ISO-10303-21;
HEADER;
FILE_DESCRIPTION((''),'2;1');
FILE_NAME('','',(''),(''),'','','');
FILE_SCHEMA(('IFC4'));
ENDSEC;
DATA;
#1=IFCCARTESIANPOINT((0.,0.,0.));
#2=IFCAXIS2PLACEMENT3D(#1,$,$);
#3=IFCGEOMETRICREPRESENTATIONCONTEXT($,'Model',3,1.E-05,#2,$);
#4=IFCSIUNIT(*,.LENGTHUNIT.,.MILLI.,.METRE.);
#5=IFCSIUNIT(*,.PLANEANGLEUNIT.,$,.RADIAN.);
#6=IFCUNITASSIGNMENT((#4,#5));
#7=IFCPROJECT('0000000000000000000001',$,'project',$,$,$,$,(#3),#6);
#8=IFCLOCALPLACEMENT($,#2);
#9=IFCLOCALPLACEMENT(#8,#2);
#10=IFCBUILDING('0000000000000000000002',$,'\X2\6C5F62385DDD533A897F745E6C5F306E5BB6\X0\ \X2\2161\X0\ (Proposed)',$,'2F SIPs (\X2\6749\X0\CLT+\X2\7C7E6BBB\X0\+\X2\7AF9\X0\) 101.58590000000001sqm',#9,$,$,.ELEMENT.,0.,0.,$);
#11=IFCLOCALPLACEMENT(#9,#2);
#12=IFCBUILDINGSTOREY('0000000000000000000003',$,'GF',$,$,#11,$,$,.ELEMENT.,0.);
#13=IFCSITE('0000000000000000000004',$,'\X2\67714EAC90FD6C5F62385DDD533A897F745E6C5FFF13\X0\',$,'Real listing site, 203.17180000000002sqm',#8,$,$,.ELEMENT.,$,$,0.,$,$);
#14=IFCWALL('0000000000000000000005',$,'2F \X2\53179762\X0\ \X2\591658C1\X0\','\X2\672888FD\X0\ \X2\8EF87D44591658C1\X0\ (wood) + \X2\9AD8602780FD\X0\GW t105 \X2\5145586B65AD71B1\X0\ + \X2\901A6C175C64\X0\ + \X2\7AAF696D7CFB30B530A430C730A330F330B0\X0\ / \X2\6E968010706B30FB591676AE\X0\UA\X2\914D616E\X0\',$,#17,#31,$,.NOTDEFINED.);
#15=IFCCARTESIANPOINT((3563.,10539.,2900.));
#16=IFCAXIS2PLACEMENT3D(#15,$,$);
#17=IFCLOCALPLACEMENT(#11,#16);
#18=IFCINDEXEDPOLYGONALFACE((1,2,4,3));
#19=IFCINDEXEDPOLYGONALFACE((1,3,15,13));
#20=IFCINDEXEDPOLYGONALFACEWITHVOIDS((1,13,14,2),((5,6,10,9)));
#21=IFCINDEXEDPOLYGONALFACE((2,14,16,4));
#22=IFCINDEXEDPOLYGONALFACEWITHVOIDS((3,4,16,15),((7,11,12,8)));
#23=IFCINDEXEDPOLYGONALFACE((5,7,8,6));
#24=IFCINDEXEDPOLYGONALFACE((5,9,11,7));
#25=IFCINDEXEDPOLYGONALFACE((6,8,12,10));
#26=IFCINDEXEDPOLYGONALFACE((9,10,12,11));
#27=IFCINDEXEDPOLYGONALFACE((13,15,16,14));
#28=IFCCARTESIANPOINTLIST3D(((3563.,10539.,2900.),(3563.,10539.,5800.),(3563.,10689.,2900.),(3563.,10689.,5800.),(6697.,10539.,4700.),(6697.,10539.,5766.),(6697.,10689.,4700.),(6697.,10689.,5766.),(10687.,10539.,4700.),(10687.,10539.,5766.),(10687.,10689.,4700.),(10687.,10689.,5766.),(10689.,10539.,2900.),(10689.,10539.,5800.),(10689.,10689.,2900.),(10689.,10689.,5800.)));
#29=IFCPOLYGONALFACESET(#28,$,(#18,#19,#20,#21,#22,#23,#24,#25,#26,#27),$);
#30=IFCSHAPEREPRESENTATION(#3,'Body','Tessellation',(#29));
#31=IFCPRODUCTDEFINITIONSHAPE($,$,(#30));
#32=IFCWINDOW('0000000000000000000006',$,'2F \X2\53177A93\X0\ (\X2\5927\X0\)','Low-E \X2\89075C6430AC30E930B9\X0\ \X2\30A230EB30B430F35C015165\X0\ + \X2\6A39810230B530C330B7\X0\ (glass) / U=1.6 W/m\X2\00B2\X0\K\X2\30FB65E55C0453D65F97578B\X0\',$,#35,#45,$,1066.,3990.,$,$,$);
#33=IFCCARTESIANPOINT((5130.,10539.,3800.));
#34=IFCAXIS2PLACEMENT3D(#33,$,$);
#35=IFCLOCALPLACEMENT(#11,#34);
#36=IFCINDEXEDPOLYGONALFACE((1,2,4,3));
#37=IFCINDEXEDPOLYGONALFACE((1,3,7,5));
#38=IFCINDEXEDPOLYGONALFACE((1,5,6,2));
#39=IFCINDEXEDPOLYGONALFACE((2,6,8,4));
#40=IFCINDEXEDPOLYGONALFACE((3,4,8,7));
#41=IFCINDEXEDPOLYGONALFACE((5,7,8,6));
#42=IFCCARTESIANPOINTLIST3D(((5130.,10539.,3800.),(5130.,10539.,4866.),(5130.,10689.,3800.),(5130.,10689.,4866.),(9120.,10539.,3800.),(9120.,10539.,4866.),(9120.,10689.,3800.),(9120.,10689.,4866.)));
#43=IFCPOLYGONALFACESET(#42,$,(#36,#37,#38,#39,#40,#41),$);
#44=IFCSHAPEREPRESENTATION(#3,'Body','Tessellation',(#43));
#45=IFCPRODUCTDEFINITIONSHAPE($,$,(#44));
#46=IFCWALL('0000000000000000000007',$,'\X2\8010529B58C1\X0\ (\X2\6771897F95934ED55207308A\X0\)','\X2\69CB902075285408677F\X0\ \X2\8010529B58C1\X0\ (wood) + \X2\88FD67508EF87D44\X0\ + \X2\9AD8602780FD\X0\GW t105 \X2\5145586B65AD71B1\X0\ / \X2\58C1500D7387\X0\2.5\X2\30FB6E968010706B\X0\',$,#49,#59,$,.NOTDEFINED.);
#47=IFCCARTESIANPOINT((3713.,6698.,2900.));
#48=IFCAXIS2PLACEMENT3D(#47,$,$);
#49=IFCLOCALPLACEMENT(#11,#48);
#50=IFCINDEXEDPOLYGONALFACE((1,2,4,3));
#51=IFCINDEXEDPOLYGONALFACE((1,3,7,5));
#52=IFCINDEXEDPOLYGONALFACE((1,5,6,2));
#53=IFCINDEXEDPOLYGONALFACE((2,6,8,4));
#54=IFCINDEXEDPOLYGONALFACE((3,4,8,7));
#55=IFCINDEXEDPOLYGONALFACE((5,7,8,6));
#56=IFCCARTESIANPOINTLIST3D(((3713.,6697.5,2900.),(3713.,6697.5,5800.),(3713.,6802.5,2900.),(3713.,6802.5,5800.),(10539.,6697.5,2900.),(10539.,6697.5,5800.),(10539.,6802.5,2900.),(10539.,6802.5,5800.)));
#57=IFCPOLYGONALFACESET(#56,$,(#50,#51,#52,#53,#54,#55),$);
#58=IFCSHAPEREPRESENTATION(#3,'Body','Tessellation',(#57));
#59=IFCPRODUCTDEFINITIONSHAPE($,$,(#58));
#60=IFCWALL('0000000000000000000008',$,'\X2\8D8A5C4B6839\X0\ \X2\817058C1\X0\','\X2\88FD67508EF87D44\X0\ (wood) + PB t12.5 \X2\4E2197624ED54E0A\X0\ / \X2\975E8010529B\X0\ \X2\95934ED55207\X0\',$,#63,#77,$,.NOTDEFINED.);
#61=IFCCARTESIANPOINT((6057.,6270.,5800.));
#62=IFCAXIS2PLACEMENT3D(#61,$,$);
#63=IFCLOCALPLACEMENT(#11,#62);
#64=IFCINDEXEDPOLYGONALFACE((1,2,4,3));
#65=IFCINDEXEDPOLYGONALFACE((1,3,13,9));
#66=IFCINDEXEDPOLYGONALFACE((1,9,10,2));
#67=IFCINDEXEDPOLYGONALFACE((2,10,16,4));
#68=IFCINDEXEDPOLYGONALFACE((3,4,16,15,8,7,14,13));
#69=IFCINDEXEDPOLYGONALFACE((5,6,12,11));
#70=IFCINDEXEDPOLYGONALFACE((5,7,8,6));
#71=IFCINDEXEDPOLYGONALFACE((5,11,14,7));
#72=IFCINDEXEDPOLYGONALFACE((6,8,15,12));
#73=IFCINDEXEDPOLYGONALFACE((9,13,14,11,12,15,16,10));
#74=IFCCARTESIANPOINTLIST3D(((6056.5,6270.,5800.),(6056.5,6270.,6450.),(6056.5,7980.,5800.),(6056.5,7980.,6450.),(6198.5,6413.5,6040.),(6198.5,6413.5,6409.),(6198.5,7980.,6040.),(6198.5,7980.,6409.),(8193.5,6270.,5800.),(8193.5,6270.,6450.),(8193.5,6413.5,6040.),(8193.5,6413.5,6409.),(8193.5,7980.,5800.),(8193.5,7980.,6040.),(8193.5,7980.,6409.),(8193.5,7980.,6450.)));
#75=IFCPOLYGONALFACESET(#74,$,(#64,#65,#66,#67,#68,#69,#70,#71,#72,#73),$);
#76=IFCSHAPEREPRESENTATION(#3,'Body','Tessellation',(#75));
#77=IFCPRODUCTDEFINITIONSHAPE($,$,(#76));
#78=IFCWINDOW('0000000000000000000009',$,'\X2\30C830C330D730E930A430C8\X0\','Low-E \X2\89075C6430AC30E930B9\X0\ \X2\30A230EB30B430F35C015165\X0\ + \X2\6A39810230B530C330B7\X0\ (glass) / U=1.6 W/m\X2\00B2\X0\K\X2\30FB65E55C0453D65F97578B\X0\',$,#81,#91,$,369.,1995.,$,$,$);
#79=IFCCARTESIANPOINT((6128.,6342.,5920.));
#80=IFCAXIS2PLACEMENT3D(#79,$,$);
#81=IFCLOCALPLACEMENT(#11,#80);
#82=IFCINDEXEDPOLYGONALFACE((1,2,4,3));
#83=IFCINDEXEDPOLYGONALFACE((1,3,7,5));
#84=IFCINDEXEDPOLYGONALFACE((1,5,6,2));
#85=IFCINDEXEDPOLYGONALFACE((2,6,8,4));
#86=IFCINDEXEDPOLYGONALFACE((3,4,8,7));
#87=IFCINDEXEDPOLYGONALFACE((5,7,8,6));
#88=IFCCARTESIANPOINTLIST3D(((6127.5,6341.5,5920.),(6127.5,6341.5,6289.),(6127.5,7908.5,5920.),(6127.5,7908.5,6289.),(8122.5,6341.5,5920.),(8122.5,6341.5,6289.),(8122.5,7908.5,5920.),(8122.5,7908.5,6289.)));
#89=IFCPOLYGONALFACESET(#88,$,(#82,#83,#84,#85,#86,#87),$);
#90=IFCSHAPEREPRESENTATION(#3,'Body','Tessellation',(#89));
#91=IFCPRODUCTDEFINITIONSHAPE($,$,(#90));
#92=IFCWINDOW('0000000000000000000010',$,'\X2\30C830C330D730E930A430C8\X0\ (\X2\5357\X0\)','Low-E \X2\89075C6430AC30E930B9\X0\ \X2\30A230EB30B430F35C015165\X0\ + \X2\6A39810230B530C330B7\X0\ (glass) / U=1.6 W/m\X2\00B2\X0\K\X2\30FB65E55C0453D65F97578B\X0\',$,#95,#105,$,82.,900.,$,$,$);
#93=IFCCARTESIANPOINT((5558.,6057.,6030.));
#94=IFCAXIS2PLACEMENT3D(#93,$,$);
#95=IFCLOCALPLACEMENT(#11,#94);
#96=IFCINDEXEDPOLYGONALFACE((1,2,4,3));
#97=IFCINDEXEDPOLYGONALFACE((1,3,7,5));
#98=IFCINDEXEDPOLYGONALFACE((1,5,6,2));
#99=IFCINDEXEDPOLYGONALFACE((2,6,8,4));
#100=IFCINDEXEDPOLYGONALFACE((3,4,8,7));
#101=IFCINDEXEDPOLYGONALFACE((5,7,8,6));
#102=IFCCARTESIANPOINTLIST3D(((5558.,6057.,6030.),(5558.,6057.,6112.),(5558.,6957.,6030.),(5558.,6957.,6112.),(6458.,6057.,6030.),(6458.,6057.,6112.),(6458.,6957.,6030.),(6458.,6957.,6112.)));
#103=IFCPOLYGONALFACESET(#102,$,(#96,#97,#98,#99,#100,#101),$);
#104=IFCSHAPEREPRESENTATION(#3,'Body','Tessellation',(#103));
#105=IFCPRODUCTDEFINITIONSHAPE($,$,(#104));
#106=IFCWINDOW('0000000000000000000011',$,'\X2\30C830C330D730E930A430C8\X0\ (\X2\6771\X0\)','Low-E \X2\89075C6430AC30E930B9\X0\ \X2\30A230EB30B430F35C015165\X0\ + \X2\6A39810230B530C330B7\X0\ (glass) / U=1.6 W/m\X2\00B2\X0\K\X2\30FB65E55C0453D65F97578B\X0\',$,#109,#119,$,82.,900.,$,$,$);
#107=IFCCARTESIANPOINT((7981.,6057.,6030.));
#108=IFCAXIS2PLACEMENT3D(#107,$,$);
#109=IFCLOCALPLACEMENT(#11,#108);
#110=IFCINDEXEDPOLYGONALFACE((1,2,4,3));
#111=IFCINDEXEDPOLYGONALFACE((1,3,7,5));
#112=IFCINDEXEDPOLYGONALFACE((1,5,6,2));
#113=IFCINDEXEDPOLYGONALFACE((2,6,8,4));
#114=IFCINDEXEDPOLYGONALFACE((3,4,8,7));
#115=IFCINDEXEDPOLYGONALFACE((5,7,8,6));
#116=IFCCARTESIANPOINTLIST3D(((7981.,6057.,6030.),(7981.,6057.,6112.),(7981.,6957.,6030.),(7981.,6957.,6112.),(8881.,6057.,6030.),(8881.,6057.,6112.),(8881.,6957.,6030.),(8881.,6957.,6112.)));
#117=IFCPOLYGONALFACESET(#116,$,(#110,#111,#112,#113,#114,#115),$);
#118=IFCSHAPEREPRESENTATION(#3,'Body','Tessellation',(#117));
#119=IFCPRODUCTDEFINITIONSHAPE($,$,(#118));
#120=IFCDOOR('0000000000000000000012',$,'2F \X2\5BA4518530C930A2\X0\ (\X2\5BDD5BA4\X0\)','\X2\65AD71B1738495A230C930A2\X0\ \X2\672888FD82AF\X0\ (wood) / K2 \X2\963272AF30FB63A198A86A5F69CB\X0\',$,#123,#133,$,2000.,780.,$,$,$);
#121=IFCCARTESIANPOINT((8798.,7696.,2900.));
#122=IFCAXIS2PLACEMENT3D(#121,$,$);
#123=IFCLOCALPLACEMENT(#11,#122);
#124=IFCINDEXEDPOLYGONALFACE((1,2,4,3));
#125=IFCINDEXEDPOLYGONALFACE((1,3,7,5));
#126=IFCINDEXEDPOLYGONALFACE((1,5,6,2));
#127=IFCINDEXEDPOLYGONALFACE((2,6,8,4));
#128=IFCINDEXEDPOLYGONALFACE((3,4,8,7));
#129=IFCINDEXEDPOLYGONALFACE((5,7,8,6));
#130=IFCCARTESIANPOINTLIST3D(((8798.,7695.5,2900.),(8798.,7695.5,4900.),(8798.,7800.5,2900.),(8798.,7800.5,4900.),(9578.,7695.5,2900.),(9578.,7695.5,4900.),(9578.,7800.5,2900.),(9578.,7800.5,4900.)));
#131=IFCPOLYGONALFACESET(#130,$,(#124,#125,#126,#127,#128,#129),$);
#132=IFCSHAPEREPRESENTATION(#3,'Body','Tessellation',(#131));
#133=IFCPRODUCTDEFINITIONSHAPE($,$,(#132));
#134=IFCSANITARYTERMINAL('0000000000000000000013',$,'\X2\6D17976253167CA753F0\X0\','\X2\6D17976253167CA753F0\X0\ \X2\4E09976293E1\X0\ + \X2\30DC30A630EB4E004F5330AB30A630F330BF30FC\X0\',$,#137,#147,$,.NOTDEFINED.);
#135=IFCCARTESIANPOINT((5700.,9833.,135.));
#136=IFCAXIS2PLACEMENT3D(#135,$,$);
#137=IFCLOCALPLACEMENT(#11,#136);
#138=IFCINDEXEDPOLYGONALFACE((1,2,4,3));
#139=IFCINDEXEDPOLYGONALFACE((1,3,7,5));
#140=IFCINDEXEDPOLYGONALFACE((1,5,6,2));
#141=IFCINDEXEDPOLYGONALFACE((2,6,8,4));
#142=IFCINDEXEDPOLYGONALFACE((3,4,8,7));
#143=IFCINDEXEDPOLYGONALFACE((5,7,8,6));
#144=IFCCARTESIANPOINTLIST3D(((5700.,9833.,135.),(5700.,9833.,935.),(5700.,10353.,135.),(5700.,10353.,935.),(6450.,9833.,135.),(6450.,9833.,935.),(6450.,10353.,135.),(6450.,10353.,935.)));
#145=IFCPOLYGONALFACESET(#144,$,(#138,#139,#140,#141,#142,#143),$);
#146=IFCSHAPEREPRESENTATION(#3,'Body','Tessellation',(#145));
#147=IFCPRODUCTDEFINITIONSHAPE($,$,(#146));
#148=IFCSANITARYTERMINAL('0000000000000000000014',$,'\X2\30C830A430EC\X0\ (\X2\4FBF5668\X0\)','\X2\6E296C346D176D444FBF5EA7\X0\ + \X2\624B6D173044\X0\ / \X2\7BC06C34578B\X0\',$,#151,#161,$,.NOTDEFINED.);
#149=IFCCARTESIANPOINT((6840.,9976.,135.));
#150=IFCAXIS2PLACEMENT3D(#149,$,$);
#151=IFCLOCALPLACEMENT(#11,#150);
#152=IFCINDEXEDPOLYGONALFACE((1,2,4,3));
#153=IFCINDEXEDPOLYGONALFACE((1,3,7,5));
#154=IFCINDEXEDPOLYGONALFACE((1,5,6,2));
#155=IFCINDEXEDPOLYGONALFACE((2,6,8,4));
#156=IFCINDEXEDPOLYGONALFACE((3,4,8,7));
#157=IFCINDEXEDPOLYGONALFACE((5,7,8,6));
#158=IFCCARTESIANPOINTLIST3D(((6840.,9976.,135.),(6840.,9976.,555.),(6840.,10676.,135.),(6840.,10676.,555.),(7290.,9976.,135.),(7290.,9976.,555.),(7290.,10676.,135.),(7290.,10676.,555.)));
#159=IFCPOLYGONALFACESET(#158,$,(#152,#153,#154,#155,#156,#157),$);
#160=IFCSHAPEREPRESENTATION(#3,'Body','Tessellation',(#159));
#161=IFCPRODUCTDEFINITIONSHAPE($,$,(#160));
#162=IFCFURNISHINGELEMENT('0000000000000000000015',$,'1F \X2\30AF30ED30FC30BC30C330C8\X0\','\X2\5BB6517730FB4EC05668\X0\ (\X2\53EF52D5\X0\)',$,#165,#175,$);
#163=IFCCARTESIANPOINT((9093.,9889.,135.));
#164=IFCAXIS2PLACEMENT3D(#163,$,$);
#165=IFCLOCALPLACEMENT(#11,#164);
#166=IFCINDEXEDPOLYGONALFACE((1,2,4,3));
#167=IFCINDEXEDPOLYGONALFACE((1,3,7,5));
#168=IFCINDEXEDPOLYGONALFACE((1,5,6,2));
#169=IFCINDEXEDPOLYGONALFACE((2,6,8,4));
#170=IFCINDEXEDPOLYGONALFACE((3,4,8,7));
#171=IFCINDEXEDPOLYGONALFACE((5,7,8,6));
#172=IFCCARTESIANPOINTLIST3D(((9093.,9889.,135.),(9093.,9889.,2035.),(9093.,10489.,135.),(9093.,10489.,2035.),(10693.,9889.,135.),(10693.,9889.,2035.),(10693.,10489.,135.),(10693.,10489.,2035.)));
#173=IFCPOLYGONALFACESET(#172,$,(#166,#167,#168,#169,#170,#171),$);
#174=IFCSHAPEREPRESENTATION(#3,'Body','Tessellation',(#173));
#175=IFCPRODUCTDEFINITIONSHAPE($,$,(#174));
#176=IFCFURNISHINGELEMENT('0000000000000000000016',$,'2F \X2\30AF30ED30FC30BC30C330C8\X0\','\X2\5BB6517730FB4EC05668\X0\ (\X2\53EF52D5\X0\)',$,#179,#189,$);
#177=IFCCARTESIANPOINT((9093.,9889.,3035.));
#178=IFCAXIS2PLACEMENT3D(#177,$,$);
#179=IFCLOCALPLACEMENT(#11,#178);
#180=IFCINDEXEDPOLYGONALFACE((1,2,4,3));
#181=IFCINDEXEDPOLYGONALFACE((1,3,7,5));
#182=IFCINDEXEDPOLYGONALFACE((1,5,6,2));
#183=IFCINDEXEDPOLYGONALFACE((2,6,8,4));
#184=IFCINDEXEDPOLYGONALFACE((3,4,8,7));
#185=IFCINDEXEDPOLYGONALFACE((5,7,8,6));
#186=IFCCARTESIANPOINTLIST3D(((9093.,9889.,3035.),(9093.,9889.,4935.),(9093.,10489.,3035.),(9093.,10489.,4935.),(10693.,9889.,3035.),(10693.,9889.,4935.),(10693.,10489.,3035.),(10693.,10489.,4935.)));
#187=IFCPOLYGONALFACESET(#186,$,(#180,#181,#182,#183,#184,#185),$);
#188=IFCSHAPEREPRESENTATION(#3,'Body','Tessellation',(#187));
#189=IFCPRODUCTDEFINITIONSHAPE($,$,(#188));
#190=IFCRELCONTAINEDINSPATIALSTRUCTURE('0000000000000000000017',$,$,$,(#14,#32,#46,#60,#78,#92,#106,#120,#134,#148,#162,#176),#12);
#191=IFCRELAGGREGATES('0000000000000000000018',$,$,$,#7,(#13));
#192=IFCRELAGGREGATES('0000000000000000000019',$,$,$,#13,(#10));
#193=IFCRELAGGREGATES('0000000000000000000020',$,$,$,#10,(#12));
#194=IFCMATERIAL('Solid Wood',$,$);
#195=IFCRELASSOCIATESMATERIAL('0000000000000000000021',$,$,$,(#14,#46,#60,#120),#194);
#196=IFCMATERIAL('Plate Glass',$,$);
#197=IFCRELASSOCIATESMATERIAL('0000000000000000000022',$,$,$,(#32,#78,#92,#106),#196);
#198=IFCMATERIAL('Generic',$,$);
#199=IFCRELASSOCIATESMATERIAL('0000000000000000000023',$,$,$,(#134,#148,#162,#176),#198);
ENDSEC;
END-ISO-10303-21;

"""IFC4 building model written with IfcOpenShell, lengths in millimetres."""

from ifc_helpers import new_model, si_unit, frame, frame_2d, origin, place, context, project, spatial, rectangle, extrude, material, element, fill, save


model = new_model("IFC4")

# Units and contexts
model_context = context("Model", 3, precision=1e-05, world=origin())
ifc_project = project(units=[si_unit("LENGTHUNIT", "METRE", prefix="MILLI"), si_unit("PLANEANGLEUNIT", "RADIAN")], contexts=[model_context])

# Site, building, storey
site_placement = place(None, origin())
site = spatial("IfcSite", under=ifc_project, at=site_placement, Name="東京都江戸川区西瑞江３", ObjectType="Real listing site, 203.17180000000002sqm", CompositionType="ELEMENT", RefElevation=0.0)
building_placement = place(site_placement, origin())
building = spatial("IfcBuilding", under=site, at=building_placement, Name="江戸川区西瑞江の家 Ⅱ (Proposed)", ObjectType="2F SIPs (杉CLT+籾殻+竹) 101.58590000000001sqm", CompositionType="ELEMENT", ElevationOfRefHeight=0.0, ElevationOfTerrain=0.0)
storey_placement = place(building_placement, origin())
storey = spatial("IfcBuildingStorey", under=building, at=storey_placement, Name="GF", CompositionType="ELEMENT", Elevation=0.0)

# Wall, opening, window
ifc_material_1 = material(Name="Solid Wood")
wall_1_placement = place(storey_placement, frame((3563.0, 10539.0, 2900.0)))
wall_1 = element("IfcWall", 1, at=wall_1_placement, inside=storey, material=ifc_material_1, Name="2F 北面 外壁", Description="木製 軸組外壁 (wood) + 高性能GW t105 充填断熱 + 通気層 + 窯業系サイディング / 準耐火・外皮UA配慮", PredefinedType="NOTDEFINED", context=model_context, shape_type="SweptSolid", body=[
    extrude(rectangle(XDim=7126.0, YDim=150.0, at=frame_2d((3563.0, 75.0))), frame((3563.0, 10539.0, 2900.0)), (0.0, 0.0, 1.0), 2900.0),
])
opening_1_placement = place(storey_placement, frame((5130.0, 10539.0, 3800.0)))
opening_1 = element("IfcOpeningElement", 2, at=opening_1_placement, cuts=wall_1, PredefinedType="NOTDEFINED", context=model_context, shape_type="SweptSolid", body=[
    extrude(rectangle(XDim=3990.0, YDim=150.0, at=frame_2d((1995.0, 75.0))), frame((5130.0, 10539.0, 3800.0)), (0.0, 0.0, 1.0), 1066.0),
])
ifc_material_2 = material(Name="Plate Glass")
window_1_placement = place(storey_placement, frame((5130.0, 10539.0, 3800.0)))
window_1 = element("IfcWindow", 3, at=window_1_placement, inside=storey, material=ifc_material_2, Name="2F 北窓 (大)", Description="Low-E 複層ガラス アルゴン封入 + 樹脂サッシ (glass) / U=1.6 W/m²K・日射取得型", OverallHeight=1066.0, OverallWidth=3990.0, context=model_context, shape_type="SweptSolid", body=[
    extrude(rectangle(XDim=3990.0, YDim=150.0, at=frame_2d((1995.0, 75.0))), frame((5130.0, 10539.0, 3800.0)), (0.0, 0.0, 1.0), 1066.0),
])
fill(opening_1, window_1)

# Wall
wall_2_placement = place(storey_placement, frame((3713.0, 6698.0, 2900.0)))
element("IfcWall", 4, at=wall_2_placement, inside=storey, material=ifc_material_1, Name="耐力壁 (東西間仕切り)", Description="構造用合板 耐力壁 (wood) + 製材軸組 + 高性能GW t105 充填断熱 / 壁倍率2.5・準耐火", PredefinedType="NOTDEFINED", context=model_context, shape_type="SweptSolid", body=[
    extrude(rectangle(XDim=6826.0, YDim=105.0, at=frame_2d((3413.0, 52.0))), frame((3713.0, 6698.0, 2900.0)), (0.0, 0.0, 1.0), 2900.0),
])

# Wall, openings, windows
wall_3_placement = place(storey_placement, frame((6057.0, 6270.0, 5800.0)))
wall_3 = element("IfcWall", 5, at=wall_3_placement, inside=storey, material=ifc_material_1, Name="越屋根 腰壁", Description="製材軸組 (wood) + PB t12.5 両面仕上 / 非耐力 間仕切", PredefinedType="NOTDEFINED", context=model_context, shape_type="SweptSolid", body=[
    extrude(rectangle(XDim=2137.0, YDim=1710.0, at=frame_2d((1068.0, 855.0))), frame((6057.0, 6270.0, 5800.0)), (0.0, 0.0, 1.0), 650.0),
])
opening_2_placement = place(storey_placement, frame((6128.0, 6342.0, 5920.0)))
opening_2 = element("IfcOpeningElement", 6, at=opening_2_placement, cuts=wall_3, PredefinedType="NOTDEFINED", context=model_context, shape_type="SweptSolid", body=[
    extrude(rectangle(XDim=1995.0, YDim=1567.0, at=frame_2d((997.0, 783.0))), frame((6128.0, 6342.0, 5920.0)), (0.0, 0.0, 1.0), 369.0),
])
opening_3_placement = place(storey_placement, frame((5558.0, 6057.0, 6030.0)))
opening_3 = element("IfcOpeningElement", 7, at=opening_3_placement, cuts=wall_3, PredefinedType="NOTDEFINED", context=model_context, shape_type="SweptSolid", body=[
    extrude(rectangle(XDim=900.0, YDim=900.0, at=frame_2d((450.0, 450.0))), frame((5558.0, 6057.0, 6030.0)), (0.0, 0.0, 1.0), 82.0),
])
opening_4_placement = place(storey_placement, frame((7981.0, 6057.0, 6030.0)))
opening_4 = element("IfcOpeningElement", 8, at=opening_4_placement, cuts=wall_3, PredefinedType="NOTDEFINED", context=model_context, shape_type="SweptSolid", body=[
    extrude(rectangle(XDim=900.0, YDim=900.0, at=frame_2d((450.0, 450.0))), frame((7981.0, 6057.0, 6030.0)), (0.0, 0.0, 1.0), 82.0),
])
window_2_placement = place(storey_placement, frame((6128.0, 6342.0, 5920.0)))
window_2 = element("IfcWindow", 9, at=window_2_placement, inside=storey, material=ifc_material_2, Name="トップライト", Description="Low-E 複層ガラス アルゴン封入 + 樹脂サッシ (glass) / U=1.6 W/m²K・日射取得型", OverallHeight=369.0, OverallWidth=1995.0, context=model_context, shape_type="SweptSolid", body=[
    extrude(rectangle(XDim=1995.0, YDim=1567.0, at=frame_2d((997.0, 783.0))), frame((6128.0, 6342.0, 5920.0)), (0.0, 0.0, 1.0), 369.0),
])
fill(opening_2, window_2)
window_3_placement = place(storey_placement, frame((5558.0, 6057.0, 6030.0)))
window_3 = element("IfcWindow", 10, at=window_3_placement, inside=storey, material=ifc_material_2, Name="トップライト (南)", Description="Low-E 複層ガラス アルゴン封入 + 樹脂サッシ (glass) / U=1.6 W/m²K・日射取得型", OverallHeight=82.0, OverallWidth=900.0, context=model_context, shape_type="SweptSolid", body=[
    extrude(rectangle(XDim=900.0, YDim=900.0, at=frame_2d((450.0, 450.0))), frame((5558.0, 6057.0, 6030.0)), (0.0, 0.0, 1.0), 82.0),
])
fill(opening_3, window_3)
window_4_placement = place(storey_placement, frame((7981.0, 6057.0, 6030.0)))
window_4 = element("IfcWindow", 11, at=window_4_placement, inside=storey, material=ifc_material_2, Name="トップライト (東)", Description="Low-E 複層ガラス アルゴン封入 + 樹脂サッシ (glass) / U=1.6 W/m²K・日射取得型", OverallHeight=82.0, OverallWidth=900.0, context=model_context, shape_type="SweptSolid", body=[
    extrude(rectangle(XDim=900.0, YDim=900.0, at=frame_2d((450.0, 450.0))), frame((7981.0, 6057.0, 6030.0)), (0.0, 0.0, 1.0), 82.0),
])
fill(opening_4, window_4)

# Door
door_placement = place(storey_placement, frame((8798.0, 7696.0, 2900.0)))
element("IfcDoor", 12, at=door_placement, inside=storey, material=ifc_material_1, Name="2F 室内ドア (寝室)", Description="断熱玄関ドア 木製芯 (wood) / K2 防犯・採風機構", OverallHeight=2000.0, OverallWidth=780.0, context=model_context, shape_type="SweptSolid", body=[
    extrude(rectangle(XDim=780.0, YDim=105.0, at=frame_2d((390.0, 52.0))), frame((8798.0, 7696.0, 2900.0)), (0.0, 0.0, 1.0), 2000.0),
])

# Sanitary terminals
ifc_material_3 = material(Name="Generic")
sanitary_terminal_1_placement = place(storey_placement, frame((5700.0, 9833.0, 135.0)))
element("IfcSanitaryTerminal", 13, at=sanitary_terminal_1_placement, inside=storey, material=ifc_material_3, Name="洗面化粧台", Description="洗面化粧台 三面鏡 + ボウル一体カウンター", PredefinedType="NOTDEFINED", context=model_context, shape_type="SweptSolid", body=[
    extrude(rectangle(XDim=750.0, YDim=520.0, at=frame_2d((375.0, 260.0))), frame((5700.0, 9833.0, 135.0)), (0.0, 0.0, 1.0), 800.0),
])
sanitary_terminal_2_placement = place(storey_placement, frame((6840.0, 9976.0, 135.0)))
element("IfcSanitaryTerminal", 14, at=sanitary_terminal_2_placement, inside=storey, material=ifc_material_3, Name="トイレ (便器)", Description="温水洗浄便座 + 手洗い / 節水型", PredefinedType="NOTDEFINED", context=model_context, shape_type="SweptSolid", body=[
    extrude(rectangle(XDim=450.0, YDim=700.0, at=frame_2d((225.0, 350.0))), frame((6840.0, 9976.0, 135.0)), (0.0, 0.0, 1.0), 420.0),
])

# Furnishing elements
furnishing_1_placement = place(storey_placement, frame((9093.0, 9889.0, 135.0)))
element("IfcFurnishingElement", 15, at=furnishing_1_placement, inside=storey, material=ifc_material_3, Name="1F クローゼット", Description="家具・什器 (可動)", context=model_context, shape_type="SweptSolid", body=[
    extrude(rectangle(XDim=1600.0, YDim=600.0, at=frame_2d((800.0, 300.0))), frame((9093.0, 9889.0, 135.0)), (0.0, 0.0, 1.0), 1900.0),
])
furnishing_2_placement = place(storey_placement, frame((9093.0, 9889.0, 3035.0)))
element("IfcFurnishingElement", 16, at=furnishing_2_placement, inside=storey, material=ifc_material_3, Name="2F クローゼット", Description="家具・什器 (可動)", context=model_context, shape_type="SweptSolid", body=[
    extrude(rectangle(XDim=1600.0, YDim=600.0, at=frame_2d((800.0, 300.0))), frame((9093.0, 9889.0, 3035.0)), (0.0, 0.0, 1.0), 1900.0),
])

save(model, "model.ifc")
